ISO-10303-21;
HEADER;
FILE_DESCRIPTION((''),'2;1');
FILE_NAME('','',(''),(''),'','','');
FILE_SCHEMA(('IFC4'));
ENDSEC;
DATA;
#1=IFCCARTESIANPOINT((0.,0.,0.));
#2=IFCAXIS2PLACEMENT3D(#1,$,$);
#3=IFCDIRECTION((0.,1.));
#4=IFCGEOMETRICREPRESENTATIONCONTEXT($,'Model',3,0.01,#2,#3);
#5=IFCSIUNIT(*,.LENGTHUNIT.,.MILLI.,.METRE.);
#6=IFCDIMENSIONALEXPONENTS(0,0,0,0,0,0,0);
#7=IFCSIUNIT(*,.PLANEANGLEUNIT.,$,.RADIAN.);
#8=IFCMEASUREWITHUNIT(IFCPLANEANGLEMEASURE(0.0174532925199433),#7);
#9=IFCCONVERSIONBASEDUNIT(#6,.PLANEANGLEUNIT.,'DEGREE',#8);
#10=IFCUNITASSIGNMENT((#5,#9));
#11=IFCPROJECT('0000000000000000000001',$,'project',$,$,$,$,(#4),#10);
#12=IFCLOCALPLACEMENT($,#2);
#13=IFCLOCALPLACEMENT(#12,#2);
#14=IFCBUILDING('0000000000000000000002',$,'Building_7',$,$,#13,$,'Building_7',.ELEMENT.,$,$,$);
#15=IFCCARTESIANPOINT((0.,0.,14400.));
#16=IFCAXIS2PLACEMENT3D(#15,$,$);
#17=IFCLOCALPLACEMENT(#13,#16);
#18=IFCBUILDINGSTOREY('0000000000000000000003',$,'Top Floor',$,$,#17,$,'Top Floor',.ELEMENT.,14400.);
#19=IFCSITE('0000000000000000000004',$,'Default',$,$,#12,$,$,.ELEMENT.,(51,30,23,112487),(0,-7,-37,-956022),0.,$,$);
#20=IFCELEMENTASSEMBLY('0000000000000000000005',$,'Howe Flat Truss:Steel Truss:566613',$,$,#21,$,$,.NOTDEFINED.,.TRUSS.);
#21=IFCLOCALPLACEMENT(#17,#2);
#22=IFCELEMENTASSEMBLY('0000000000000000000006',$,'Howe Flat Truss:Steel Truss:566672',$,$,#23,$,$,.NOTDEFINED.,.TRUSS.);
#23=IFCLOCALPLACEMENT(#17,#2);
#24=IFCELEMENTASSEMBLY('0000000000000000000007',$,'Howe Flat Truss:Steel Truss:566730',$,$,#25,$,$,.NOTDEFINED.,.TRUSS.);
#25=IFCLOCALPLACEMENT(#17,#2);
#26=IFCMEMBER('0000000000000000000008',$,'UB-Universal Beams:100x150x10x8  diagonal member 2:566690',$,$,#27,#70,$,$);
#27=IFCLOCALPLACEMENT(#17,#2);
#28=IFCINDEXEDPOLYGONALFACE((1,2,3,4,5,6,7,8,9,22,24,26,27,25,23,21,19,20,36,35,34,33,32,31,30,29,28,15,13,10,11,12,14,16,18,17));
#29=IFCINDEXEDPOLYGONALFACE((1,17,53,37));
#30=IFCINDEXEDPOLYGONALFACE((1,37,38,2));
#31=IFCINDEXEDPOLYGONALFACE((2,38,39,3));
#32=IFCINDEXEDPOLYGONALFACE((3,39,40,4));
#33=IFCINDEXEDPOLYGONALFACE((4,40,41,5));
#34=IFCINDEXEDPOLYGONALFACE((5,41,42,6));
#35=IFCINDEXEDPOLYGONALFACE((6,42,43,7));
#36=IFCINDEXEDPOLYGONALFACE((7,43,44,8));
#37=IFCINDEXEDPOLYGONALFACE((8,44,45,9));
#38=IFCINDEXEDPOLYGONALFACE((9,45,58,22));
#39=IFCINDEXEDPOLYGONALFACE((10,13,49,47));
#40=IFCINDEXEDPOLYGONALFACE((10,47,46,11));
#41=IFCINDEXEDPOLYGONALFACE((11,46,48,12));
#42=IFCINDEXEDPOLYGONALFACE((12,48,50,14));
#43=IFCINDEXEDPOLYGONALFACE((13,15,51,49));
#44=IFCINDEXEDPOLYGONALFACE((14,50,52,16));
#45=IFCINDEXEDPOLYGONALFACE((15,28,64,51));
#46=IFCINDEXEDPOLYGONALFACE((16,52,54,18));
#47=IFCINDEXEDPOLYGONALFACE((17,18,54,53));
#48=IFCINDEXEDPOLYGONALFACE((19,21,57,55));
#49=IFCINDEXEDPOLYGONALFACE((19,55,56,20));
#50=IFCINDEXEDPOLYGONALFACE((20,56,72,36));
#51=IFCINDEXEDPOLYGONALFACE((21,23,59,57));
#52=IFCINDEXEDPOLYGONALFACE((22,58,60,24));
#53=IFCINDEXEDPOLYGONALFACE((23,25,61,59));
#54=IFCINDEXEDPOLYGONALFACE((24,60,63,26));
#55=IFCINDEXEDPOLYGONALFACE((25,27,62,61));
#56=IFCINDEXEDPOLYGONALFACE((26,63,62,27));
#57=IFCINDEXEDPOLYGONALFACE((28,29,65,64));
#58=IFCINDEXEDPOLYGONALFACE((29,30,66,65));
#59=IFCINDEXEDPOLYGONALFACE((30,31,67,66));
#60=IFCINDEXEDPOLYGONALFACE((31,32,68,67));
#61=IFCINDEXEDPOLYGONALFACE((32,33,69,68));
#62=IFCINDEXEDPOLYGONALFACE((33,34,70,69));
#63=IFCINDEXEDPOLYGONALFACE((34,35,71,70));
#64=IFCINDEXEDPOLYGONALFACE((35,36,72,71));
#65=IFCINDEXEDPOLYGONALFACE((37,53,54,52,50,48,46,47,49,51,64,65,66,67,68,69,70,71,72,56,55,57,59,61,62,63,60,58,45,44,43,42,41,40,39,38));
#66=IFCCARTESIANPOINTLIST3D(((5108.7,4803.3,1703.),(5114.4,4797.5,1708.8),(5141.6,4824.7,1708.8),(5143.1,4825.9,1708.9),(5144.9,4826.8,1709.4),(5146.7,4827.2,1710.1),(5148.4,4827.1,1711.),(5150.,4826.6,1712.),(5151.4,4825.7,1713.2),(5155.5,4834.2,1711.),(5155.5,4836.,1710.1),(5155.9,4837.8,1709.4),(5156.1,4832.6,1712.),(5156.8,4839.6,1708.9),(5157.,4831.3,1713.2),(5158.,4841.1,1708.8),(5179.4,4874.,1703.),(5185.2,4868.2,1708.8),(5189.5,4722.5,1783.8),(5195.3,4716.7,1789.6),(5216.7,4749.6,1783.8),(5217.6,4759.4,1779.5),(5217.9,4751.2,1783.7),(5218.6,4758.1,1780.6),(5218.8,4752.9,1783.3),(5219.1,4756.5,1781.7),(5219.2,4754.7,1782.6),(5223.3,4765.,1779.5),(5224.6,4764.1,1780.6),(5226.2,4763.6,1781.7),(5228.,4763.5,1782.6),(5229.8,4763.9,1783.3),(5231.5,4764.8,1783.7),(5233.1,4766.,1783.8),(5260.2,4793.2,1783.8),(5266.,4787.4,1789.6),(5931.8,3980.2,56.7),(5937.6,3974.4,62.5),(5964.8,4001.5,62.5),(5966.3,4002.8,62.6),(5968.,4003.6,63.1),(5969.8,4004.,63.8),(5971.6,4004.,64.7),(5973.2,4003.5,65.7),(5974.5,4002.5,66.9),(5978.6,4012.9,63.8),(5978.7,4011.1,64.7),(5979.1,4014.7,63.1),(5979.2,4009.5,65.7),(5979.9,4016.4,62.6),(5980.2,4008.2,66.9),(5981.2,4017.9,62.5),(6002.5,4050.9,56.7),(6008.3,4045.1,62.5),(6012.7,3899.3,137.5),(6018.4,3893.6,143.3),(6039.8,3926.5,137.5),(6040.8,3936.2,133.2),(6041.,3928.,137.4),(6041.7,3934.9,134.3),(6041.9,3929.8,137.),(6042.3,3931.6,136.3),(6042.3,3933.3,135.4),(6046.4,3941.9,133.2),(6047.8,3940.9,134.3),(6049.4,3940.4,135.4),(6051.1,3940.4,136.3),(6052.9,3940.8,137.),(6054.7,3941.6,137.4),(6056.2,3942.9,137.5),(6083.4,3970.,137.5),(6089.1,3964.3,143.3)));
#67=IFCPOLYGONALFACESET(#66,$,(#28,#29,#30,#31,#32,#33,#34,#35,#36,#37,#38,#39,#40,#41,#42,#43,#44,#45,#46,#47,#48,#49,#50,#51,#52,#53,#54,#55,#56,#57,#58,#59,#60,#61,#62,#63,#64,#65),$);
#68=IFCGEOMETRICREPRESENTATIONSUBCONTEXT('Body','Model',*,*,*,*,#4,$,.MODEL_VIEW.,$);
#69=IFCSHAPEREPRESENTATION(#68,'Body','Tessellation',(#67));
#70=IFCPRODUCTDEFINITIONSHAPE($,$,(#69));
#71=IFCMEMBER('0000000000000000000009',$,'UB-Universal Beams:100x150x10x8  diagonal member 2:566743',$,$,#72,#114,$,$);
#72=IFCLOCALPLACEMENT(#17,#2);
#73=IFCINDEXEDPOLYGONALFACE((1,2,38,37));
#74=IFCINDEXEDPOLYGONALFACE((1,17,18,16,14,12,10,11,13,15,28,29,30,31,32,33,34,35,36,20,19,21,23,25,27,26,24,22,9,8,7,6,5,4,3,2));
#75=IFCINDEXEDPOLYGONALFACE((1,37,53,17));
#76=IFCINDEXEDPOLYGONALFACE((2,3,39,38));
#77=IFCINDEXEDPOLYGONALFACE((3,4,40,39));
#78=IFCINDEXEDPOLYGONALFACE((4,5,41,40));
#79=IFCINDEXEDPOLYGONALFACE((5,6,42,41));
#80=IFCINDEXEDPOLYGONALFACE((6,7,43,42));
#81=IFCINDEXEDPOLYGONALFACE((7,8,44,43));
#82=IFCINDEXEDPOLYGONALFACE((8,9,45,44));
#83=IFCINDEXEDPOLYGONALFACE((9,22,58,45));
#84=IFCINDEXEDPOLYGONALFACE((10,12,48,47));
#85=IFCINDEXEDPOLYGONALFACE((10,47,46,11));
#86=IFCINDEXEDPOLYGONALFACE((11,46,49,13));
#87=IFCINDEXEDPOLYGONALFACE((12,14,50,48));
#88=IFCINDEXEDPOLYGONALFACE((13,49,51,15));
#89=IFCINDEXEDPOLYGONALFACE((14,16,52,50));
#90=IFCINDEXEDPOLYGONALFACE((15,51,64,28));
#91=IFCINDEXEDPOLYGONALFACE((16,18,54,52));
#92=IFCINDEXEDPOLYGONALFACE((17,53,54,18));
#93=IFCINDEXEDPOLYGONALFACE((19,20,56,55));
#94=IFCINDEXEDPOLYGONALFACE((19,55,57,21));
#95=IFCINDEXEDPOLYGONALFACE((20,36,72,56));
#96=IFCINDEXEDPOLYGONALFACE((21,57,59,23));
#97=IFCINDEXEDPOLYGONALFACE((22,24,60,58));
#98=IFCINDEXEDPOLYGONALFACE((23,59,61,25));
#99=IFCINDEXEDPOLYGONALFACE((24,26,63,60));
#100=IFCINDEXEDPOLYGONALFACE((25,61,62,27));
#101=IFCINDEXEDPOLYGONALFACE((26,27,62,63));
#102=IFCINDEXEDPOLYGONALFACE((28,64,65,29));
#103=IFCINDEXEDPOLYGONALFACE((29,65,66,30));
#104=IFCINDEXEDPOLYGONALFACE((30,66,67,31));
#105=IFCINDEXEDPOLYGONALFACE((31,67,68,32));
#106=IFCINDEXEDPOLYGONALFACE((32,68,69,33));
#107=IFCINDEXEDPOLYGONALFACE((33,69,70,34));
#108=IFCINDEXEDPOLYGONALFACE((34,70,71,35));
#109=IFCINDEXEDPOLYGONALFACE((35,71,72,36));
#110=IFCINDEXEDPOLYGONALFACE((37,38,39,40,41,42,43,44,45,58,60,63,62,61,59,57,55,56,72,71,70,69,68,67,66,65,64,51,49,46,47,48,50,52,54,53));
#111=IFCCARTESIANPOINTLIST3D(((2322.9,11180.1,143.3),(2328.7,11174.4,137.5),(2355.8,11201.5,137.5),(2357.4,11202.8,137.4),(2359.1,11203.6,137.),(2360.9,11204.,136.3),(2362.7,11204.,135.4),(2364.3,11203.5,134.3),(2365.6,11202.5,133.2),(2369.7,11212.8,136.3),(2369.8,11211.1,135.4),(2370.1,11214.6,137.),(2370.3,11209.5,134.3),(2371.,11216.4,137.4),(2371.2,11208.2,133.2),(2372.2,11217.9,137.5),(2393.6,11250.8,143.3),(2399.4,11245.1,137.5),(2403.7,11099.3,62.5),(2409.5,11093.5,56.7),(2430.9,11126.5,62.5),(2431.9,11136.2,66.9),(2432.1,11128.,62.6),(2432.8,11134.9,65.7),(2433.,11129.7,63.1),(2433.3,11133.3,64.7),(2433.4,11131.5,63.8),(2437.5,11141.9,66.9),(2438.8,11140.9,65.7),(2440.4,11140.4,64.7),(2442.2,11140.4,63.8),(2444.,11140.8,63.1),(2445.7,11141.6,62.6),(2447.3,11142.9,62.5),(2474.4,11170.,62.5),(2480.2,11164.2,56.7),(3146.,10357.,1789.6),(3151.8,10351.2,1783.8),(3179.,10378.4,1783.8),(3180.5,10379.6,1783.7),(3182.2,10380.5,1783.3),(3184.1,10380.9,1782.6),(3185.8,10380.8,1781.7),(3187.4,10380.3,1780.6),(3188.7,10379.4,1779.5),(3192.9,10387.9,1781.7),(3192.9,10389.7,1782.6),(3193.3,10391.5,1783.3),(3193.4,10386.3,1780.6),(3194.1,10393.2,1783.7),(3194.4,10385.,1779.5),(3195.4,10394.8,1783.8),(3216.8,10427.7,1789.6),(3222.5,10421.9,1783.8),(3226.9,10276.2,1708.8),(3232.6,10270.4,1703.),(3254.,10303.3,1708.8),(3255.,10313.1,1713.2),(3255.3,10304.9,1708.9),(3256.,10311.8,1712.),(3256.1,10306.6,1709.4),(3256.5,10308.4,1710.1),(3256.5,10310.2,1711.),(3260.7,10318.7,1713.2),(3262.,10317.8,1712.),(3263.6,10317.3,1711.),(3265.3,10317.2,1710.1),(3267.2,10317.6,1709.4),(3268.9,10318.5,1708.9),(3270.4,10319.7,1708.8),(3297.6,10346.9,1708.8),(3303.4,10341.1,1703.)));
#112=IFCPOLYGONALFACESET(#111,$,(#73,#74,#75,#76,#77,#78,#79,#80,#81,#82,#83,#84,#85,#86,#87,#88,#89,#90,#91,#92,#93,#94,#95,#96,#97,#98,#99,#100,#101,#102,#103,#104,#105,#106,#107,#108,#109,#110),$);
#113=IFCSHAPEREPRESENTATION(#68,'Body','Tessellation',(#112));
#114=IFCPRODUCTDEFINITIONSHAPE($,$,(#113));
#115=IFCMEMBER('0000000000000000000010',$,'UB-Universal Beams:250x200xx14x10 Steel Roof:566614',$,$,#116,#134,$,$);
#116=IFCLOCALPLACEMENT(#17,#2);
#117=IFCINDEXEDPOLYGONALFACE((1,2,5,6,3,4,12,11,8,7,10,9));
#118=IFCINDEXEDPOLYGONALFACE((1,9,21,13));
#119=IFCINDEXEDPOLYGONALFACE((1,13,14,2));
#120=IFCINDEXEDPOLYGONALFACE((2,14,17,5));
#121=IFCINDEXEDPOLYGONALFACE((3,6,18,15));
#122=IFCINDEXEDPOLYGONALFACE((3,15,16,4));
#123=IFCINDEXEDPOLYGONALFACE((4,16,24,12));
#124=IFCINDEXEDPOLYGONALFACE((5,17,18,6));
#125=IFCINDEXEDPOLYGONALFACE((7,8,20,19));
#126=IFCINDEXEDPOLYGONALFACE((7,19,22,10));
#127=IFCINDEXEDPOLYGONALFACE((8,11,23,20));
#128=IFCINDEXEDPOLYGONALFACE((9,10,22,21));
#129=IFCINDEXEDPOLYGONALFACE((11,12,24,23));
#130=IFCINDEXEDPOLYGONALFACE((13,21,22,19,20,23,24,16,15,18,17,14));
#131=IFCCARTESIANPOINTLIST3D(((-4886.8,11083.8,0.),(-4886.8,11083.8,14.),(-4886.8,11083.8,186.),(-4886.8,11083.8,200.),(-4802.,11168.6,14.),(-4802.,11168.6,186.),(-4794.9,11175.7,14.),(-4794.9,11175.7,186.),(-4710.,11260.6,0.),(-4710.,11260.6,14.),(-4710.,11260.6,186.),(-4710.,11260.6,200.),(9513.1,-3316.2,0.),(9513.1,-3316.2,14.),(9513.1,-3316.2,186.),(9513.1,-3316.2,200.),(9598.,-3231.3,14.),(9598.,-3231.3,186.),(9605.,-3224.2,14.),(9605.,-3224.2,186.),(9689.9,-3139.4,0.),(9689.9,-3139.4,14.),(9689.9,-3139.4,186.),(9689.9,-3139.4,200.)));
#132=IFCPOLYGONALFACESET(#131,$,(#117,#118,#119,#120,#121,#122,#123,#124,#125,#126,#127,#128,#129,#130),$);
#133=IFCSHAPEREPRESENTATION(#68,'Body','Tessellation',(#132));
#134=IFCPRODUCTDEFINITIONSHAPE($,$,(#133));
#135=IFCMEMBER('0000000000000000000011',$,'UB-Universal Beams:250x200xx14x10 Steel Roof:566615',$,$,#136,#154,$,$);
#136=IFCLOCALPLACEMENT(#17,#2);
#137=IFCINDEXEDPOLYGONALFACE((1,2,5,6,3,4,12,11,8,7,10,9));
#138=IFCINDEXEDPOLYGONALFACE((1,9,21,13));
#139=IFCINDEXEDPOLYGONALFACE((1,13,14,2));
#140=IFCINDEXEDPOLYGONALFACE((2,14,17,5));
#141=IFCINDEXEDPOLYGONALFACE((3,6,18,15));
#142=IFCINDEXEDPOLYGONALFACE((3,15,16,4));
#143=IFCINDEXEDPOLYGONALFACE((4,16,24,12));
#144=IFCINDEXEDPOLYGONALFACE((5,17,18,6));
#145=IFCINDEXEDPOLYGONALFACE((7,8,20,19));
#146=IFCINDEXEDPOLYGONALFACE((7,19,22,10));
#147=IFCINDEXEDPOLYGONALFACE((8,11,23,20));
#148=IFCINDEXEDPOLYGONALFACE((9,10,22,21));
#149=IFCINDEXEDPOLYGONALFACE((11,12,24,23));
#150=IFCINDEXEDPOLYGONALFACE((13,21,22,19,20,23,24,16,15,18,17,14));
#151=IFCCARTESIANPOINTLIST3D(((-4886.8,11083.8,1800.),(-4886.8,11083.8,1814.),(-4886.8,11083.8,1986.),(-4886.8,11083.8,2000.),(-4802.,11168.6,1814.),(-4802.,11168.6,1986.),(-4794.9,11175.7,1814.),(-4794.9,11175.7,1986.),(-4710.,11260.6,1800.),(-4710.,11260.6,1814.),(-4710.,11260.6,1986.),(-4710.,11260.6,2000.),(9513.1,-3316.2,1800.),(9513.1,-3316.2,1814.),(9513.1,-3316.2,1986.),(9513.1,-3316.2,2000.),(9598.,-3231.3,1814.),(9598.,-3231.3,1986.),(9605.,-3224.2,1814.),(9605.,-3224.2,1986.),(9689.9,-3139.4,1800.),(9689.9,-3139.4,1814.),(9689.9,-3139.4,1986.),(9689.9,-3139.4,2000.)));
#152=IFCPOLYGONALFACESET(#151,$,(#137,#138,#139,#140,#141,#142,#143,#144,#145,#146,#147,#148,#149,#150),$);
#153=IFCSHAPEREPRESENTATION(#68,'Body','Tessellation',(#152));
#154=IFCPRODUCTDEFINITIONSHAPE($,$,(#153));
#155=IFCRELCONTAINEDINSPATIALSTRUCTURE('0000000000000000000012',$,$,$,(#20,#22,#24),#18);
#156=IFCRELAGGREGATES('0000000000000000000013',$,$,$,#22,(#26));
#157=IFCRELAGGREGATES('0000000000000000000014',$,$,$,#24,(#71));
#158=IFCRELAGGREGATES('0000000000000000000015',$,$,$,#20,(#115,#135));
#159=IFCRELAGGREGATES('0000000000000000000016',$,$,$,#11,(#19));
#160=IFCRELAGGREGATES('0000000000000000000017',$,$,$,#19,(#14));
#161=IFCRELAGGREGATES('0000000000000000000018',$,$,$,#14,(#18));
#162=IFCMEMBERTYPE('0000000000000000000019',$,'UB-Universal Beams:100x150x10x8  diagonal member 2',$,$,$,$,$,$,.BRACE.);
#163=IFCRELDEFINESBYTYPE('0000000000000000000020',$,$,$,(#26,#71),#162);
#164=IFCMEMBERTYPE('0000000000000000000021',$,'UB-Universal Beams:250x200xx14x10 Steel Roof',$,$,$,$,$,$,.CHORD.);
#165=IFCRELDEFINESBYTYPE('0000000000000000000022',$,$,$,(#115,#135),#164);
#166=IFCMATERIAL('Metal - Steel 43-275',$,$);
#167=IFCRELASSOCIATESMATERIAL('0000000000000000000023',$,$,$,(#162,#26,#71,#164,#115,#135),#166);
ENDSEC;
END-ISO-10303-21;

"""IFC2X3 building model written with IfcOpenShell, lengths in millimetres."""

from ifc_helpers import new_model, entity, si_unit, converted_unit, direction, frame, frame_2d, origin, place, context, subcontext, project, spatial, polyline, circle_curve, parameter, trimmed, segment, composite_curve, outline, extrude, source, transform, mapped, material, type_object, type_shapes, element, aggregate, save


model = new_model("IFC2X3")

# Units and contexts
model_context = context("Model", 3, precision=0.01, world=origin(), true_north=direction((0.0, 1.0)))
body_context = subcontext(model_context, "Body", "Model", "MODEL_VIEW")
ifc_project = project(units=[si_unit("LENGTHUNIT", "METRE", prefix="MILLI"), converted_unit("PLANEANGLEUNIT", "DEGREE", entity("IfcPlaneAngleMeasure", 0.0174532925199433), si_unit("PLANEANGLEUNIT", "RADIAN"), dimensions=[0, 0, 0, 0, 0, 0, 0])], contexts=[model_context])

# Site, building, storey
site_placement = place(None, origin())
site = spatial("IfcSite", under=ifc_project, at=site_placement, Name="Default", CompositionType="ELEMENT", RefLatitude=(51, 30, 23, 112487), RefLongitude=(0, -7, -37, -956022), RefElevation=0.0)
building_placement = place(site_placement, origin())
building = spatial("IfcBuilding", under=site, at=building_placement, Name="Building_7", LongName="Building_7", CompositionType="ELEMENT")
storey_placement = place(building_placement, frame((0.0, 0.0, 14400.0)))
storey = spatial("IfcBuildingStorey", under=building, at=storey_placement, Name="Top Floor", LongName="Top Floor", CompositionType="ELEMENT", Elevation=14400.0)

# Shared definitions
ifc_material = material(Name="Metal - Steel 43-275")

# Element assemblies
assembly_1_placement = place(storey_placement, origin())
assembly_1 = element("IfcElementAssembly", 1, at=assembly_1_placement, inside=storey, Name="Howe Flat Truss:Steel Truss:566613", AssemblyPlace="NOTDEFINED", PredefinedType="TRUSS")
assembly_2_placement = place(storey_placement, origin())
assembly_2 = element("IfcElementAssembly", 2, at=assembly_2_placement, inside=storey, Name="Howe Flat Truss:Steel Truss:566672", AssemblyPlace="NOTDEFINED", PredefinedType="TRUSS")
assembly_3_placement = place(storey_placement, origin())
assembly_3 = element("IfcElementAssembly", 3, at=assembly_3_placement, inside=storey, Name="Howe Flat Truss:Steel Truss:566730", AssemblyPlace="NOTDEFINED", PredefinedType="TRUSS")

# Members
member_type_1 = type_object("IfcMemberType", Name="UB-Universal Beams:100x150x10x8  diagonal member 2", PredefinedType="BRACE", material=ifc_material)
shared_shape_1 = source(origin(), body_context, "Body", "SweptSolid", [
    extrude(outline(composite_curve([segment(polyline([(-50.0, -65.0), (-50.0, -75.0)]), True, "CONTINUOUS"), segment(polyline([(-50.0, -75.0), (50.0, -75.0)]), True, "CONTINUOUS"), segment(polyline([(50.0, -75.0), (50.0, -65.0)]), True, "CONTINUOUS"), segment(polyline([(50.0, -65.0), (11.6, -65.0)]), True, "CONTINUOUS"), segment(trimmed(circle_curve(frame_2d((11.6, -57.4), x_axis=(1.0, 0.0)), 7.6), [parameter(180.0)], [parameter(270.0)], True, "PARAMETER"), False, "CONTINUOUS"), segment(polyline([(4.0, -57.4), (4.0, 57.4)]), True, "CONTINUOUS"), segment(trimmed(circle_curve(frame_2d((11.6, 57.4), x_axis=(1.0, 0.0)), 7.6), [parameter(90.0)], [parameter(180.0)], True, "PARAMETER"), False, "CONTINUOUS"), segment(polyline([(11.6, 65.0), (50.0, 65.0)]), True, "CONTINUOUS"), segment(polyline([(50.0, 65.0), (50.0, 75.0)]), True, "CONTINUOUS"), segment(polyline([(50.0, 75.0), (-50.0, 75.0)]), True, "CONTINUOUS"), segment(polyline([(-50.0, 75.0), (-50.0, 65.0)]), True, "CONTINUOUS"), segment(polyline([(-50.0, 65.0), (-11.6, 65.0)]), True, "CONTINUOUS"), segment(trimmed(circle_curve(frame_2d((-11.6, 57.4), x_axis=(1.0, 0.0)), 7.6), [parameter(360.0)], [parameter(90.0)], True, "PARAMETER"), False, "CONTINUOUS"), segment(polyline([(-4.0, 57.4), (-4.0, -57.4)]), True, "CONTINUOUS"), segment(trimmed(circle_curve(frame_2d((-11.6, -57.4), x_axis=(1.0, 0.0)), 7.6), [parameter(270.0)], [parameter(360.0)], True, "PARAMETER"), False, "CONTINUOUS"), segment(polyline([(-11.6, -65.0), (-50.0, -65.0)]), True, "CONTINUOUS")], self_intersect=False)), frame((-1102.2, 0.0, 0.0), z_axis=(-1.0, 0.0, 0.0), x_axis=(0.0, -1.0, 0.0)), (0.0, 0.0, -1.0), 2016.3),
])
type_shapes(member_type_1, [shared_shape_1])
member_1_placement = place(assembly_2_placement, frame((5560.5, 4422.2, 1000.0), z_axis=(-0.57735, 0.57735, -0.57735), x_axis=(-0.408248, 0.408248, 0.816497)))
member_1 = element("IfcMember", 4, at=member_1_placement, type_object=member_type_1, material=ifc_material, Name="UB-Universal Beams:100x150x10x8  diagonal member 2:566690", context=body_context, shape_type="MappedRepresentation", body=[
    mapped(shared_shape_1, transform((0.0, 0.0, 0.0), scale=1.0)),
])
aggregate(assembly_2, [member_1])
member_2_placement = place(assembly_3_placement, frame((2851.5, 10722.2, 1000.0), z_axis=(0.57735, -0.57735, -0.57735), x_axis=(0.408248, -0.408248, 0.816497)))
member_2 = element("IfcMember", 5, at=member_2_placement, type_object=member_type_1, material=ifc_material, Name="UB-Universal Beams:100x150x10x8  diagonal member 2:566743", context=body_context, shape_type="MappedRepresentation", body=[
    mapped(shared_shape_1, transform((0.0, 0.0, 0.0), scale=1.0)),
])
aggregate(assembly_3, [member_2])
member_type_2 = type_object("IfcMemberType", Name="UB-Universal Beams:250x200xx14x10 Steel Roof", PredefinedType="CHORD", material=ifc_material)
shared_shape_2 = source(origin(), body_context, "Body", "SweptSolid", [
    extrude(outline(polyline([(-125.0, -86.0), (-125.0, -100.0), (125.0, -100.0), (125.0, -86.0), (5.0, -86.0), (5.0, 86.0), (125.0, 86.0), (125.0, 100.0), (-125.0, 100.0), (-125.0, 86.0), (-5.0, 86.0), (-5.0, -86.0), (-125.0, -86.0)])), frame((-10182.3, 0.0, 0.0), z_axis=(-1.0, 0.0, 0.0), x_axis=(0.0, -1.0, 0.0)), (0.0, 0.0, -1.0), 20364.6),
])
type_shapes(member_type_2, [shared_shape_2])
member_3_placement = place(assembly_1_placement, frame((2401.5, 3972.2, 100.0), z_axis=(0.0, 0.0, 1.0), x_axis=(0.707107, -0.707107, 0.0)))
member_3 = element("IfcMember", 6, at=member_3_placement, type_object=member_type_2, material=ifc_material, Name="UB-Universal Beams:250x200xx14x10 Steel Roof:566614", context=body_context, shape_type="MappedRepresentation", body=[
    mapped(shared_shape_2, transform((0.0, 0.0, 0.0), scale=1.0)),
])
member_4_placement = place(assembly_1_placement, frame((2401.5, 3972.2, 1900.0), z_axis=(0.0, 0.0, 1.0), x_axis=(0.707107, -0.707107, 0.0)))
member_4 = element("IfcMember", 7, at=member_4_placement, type_object=member_type_2, material=ifc_material, Name="UB-Universal Beams:250x200xx14x10 Steel Roof:566615", context=body_context, shape_type="MappedRepresentation", body=[
    mapped(shared_shape_2, transform((0.0, 0.0, 0.0), scale=1.0)),
])
aggregate(assembly_1, [member_3, member_4])

save(model, "model.ifc")
